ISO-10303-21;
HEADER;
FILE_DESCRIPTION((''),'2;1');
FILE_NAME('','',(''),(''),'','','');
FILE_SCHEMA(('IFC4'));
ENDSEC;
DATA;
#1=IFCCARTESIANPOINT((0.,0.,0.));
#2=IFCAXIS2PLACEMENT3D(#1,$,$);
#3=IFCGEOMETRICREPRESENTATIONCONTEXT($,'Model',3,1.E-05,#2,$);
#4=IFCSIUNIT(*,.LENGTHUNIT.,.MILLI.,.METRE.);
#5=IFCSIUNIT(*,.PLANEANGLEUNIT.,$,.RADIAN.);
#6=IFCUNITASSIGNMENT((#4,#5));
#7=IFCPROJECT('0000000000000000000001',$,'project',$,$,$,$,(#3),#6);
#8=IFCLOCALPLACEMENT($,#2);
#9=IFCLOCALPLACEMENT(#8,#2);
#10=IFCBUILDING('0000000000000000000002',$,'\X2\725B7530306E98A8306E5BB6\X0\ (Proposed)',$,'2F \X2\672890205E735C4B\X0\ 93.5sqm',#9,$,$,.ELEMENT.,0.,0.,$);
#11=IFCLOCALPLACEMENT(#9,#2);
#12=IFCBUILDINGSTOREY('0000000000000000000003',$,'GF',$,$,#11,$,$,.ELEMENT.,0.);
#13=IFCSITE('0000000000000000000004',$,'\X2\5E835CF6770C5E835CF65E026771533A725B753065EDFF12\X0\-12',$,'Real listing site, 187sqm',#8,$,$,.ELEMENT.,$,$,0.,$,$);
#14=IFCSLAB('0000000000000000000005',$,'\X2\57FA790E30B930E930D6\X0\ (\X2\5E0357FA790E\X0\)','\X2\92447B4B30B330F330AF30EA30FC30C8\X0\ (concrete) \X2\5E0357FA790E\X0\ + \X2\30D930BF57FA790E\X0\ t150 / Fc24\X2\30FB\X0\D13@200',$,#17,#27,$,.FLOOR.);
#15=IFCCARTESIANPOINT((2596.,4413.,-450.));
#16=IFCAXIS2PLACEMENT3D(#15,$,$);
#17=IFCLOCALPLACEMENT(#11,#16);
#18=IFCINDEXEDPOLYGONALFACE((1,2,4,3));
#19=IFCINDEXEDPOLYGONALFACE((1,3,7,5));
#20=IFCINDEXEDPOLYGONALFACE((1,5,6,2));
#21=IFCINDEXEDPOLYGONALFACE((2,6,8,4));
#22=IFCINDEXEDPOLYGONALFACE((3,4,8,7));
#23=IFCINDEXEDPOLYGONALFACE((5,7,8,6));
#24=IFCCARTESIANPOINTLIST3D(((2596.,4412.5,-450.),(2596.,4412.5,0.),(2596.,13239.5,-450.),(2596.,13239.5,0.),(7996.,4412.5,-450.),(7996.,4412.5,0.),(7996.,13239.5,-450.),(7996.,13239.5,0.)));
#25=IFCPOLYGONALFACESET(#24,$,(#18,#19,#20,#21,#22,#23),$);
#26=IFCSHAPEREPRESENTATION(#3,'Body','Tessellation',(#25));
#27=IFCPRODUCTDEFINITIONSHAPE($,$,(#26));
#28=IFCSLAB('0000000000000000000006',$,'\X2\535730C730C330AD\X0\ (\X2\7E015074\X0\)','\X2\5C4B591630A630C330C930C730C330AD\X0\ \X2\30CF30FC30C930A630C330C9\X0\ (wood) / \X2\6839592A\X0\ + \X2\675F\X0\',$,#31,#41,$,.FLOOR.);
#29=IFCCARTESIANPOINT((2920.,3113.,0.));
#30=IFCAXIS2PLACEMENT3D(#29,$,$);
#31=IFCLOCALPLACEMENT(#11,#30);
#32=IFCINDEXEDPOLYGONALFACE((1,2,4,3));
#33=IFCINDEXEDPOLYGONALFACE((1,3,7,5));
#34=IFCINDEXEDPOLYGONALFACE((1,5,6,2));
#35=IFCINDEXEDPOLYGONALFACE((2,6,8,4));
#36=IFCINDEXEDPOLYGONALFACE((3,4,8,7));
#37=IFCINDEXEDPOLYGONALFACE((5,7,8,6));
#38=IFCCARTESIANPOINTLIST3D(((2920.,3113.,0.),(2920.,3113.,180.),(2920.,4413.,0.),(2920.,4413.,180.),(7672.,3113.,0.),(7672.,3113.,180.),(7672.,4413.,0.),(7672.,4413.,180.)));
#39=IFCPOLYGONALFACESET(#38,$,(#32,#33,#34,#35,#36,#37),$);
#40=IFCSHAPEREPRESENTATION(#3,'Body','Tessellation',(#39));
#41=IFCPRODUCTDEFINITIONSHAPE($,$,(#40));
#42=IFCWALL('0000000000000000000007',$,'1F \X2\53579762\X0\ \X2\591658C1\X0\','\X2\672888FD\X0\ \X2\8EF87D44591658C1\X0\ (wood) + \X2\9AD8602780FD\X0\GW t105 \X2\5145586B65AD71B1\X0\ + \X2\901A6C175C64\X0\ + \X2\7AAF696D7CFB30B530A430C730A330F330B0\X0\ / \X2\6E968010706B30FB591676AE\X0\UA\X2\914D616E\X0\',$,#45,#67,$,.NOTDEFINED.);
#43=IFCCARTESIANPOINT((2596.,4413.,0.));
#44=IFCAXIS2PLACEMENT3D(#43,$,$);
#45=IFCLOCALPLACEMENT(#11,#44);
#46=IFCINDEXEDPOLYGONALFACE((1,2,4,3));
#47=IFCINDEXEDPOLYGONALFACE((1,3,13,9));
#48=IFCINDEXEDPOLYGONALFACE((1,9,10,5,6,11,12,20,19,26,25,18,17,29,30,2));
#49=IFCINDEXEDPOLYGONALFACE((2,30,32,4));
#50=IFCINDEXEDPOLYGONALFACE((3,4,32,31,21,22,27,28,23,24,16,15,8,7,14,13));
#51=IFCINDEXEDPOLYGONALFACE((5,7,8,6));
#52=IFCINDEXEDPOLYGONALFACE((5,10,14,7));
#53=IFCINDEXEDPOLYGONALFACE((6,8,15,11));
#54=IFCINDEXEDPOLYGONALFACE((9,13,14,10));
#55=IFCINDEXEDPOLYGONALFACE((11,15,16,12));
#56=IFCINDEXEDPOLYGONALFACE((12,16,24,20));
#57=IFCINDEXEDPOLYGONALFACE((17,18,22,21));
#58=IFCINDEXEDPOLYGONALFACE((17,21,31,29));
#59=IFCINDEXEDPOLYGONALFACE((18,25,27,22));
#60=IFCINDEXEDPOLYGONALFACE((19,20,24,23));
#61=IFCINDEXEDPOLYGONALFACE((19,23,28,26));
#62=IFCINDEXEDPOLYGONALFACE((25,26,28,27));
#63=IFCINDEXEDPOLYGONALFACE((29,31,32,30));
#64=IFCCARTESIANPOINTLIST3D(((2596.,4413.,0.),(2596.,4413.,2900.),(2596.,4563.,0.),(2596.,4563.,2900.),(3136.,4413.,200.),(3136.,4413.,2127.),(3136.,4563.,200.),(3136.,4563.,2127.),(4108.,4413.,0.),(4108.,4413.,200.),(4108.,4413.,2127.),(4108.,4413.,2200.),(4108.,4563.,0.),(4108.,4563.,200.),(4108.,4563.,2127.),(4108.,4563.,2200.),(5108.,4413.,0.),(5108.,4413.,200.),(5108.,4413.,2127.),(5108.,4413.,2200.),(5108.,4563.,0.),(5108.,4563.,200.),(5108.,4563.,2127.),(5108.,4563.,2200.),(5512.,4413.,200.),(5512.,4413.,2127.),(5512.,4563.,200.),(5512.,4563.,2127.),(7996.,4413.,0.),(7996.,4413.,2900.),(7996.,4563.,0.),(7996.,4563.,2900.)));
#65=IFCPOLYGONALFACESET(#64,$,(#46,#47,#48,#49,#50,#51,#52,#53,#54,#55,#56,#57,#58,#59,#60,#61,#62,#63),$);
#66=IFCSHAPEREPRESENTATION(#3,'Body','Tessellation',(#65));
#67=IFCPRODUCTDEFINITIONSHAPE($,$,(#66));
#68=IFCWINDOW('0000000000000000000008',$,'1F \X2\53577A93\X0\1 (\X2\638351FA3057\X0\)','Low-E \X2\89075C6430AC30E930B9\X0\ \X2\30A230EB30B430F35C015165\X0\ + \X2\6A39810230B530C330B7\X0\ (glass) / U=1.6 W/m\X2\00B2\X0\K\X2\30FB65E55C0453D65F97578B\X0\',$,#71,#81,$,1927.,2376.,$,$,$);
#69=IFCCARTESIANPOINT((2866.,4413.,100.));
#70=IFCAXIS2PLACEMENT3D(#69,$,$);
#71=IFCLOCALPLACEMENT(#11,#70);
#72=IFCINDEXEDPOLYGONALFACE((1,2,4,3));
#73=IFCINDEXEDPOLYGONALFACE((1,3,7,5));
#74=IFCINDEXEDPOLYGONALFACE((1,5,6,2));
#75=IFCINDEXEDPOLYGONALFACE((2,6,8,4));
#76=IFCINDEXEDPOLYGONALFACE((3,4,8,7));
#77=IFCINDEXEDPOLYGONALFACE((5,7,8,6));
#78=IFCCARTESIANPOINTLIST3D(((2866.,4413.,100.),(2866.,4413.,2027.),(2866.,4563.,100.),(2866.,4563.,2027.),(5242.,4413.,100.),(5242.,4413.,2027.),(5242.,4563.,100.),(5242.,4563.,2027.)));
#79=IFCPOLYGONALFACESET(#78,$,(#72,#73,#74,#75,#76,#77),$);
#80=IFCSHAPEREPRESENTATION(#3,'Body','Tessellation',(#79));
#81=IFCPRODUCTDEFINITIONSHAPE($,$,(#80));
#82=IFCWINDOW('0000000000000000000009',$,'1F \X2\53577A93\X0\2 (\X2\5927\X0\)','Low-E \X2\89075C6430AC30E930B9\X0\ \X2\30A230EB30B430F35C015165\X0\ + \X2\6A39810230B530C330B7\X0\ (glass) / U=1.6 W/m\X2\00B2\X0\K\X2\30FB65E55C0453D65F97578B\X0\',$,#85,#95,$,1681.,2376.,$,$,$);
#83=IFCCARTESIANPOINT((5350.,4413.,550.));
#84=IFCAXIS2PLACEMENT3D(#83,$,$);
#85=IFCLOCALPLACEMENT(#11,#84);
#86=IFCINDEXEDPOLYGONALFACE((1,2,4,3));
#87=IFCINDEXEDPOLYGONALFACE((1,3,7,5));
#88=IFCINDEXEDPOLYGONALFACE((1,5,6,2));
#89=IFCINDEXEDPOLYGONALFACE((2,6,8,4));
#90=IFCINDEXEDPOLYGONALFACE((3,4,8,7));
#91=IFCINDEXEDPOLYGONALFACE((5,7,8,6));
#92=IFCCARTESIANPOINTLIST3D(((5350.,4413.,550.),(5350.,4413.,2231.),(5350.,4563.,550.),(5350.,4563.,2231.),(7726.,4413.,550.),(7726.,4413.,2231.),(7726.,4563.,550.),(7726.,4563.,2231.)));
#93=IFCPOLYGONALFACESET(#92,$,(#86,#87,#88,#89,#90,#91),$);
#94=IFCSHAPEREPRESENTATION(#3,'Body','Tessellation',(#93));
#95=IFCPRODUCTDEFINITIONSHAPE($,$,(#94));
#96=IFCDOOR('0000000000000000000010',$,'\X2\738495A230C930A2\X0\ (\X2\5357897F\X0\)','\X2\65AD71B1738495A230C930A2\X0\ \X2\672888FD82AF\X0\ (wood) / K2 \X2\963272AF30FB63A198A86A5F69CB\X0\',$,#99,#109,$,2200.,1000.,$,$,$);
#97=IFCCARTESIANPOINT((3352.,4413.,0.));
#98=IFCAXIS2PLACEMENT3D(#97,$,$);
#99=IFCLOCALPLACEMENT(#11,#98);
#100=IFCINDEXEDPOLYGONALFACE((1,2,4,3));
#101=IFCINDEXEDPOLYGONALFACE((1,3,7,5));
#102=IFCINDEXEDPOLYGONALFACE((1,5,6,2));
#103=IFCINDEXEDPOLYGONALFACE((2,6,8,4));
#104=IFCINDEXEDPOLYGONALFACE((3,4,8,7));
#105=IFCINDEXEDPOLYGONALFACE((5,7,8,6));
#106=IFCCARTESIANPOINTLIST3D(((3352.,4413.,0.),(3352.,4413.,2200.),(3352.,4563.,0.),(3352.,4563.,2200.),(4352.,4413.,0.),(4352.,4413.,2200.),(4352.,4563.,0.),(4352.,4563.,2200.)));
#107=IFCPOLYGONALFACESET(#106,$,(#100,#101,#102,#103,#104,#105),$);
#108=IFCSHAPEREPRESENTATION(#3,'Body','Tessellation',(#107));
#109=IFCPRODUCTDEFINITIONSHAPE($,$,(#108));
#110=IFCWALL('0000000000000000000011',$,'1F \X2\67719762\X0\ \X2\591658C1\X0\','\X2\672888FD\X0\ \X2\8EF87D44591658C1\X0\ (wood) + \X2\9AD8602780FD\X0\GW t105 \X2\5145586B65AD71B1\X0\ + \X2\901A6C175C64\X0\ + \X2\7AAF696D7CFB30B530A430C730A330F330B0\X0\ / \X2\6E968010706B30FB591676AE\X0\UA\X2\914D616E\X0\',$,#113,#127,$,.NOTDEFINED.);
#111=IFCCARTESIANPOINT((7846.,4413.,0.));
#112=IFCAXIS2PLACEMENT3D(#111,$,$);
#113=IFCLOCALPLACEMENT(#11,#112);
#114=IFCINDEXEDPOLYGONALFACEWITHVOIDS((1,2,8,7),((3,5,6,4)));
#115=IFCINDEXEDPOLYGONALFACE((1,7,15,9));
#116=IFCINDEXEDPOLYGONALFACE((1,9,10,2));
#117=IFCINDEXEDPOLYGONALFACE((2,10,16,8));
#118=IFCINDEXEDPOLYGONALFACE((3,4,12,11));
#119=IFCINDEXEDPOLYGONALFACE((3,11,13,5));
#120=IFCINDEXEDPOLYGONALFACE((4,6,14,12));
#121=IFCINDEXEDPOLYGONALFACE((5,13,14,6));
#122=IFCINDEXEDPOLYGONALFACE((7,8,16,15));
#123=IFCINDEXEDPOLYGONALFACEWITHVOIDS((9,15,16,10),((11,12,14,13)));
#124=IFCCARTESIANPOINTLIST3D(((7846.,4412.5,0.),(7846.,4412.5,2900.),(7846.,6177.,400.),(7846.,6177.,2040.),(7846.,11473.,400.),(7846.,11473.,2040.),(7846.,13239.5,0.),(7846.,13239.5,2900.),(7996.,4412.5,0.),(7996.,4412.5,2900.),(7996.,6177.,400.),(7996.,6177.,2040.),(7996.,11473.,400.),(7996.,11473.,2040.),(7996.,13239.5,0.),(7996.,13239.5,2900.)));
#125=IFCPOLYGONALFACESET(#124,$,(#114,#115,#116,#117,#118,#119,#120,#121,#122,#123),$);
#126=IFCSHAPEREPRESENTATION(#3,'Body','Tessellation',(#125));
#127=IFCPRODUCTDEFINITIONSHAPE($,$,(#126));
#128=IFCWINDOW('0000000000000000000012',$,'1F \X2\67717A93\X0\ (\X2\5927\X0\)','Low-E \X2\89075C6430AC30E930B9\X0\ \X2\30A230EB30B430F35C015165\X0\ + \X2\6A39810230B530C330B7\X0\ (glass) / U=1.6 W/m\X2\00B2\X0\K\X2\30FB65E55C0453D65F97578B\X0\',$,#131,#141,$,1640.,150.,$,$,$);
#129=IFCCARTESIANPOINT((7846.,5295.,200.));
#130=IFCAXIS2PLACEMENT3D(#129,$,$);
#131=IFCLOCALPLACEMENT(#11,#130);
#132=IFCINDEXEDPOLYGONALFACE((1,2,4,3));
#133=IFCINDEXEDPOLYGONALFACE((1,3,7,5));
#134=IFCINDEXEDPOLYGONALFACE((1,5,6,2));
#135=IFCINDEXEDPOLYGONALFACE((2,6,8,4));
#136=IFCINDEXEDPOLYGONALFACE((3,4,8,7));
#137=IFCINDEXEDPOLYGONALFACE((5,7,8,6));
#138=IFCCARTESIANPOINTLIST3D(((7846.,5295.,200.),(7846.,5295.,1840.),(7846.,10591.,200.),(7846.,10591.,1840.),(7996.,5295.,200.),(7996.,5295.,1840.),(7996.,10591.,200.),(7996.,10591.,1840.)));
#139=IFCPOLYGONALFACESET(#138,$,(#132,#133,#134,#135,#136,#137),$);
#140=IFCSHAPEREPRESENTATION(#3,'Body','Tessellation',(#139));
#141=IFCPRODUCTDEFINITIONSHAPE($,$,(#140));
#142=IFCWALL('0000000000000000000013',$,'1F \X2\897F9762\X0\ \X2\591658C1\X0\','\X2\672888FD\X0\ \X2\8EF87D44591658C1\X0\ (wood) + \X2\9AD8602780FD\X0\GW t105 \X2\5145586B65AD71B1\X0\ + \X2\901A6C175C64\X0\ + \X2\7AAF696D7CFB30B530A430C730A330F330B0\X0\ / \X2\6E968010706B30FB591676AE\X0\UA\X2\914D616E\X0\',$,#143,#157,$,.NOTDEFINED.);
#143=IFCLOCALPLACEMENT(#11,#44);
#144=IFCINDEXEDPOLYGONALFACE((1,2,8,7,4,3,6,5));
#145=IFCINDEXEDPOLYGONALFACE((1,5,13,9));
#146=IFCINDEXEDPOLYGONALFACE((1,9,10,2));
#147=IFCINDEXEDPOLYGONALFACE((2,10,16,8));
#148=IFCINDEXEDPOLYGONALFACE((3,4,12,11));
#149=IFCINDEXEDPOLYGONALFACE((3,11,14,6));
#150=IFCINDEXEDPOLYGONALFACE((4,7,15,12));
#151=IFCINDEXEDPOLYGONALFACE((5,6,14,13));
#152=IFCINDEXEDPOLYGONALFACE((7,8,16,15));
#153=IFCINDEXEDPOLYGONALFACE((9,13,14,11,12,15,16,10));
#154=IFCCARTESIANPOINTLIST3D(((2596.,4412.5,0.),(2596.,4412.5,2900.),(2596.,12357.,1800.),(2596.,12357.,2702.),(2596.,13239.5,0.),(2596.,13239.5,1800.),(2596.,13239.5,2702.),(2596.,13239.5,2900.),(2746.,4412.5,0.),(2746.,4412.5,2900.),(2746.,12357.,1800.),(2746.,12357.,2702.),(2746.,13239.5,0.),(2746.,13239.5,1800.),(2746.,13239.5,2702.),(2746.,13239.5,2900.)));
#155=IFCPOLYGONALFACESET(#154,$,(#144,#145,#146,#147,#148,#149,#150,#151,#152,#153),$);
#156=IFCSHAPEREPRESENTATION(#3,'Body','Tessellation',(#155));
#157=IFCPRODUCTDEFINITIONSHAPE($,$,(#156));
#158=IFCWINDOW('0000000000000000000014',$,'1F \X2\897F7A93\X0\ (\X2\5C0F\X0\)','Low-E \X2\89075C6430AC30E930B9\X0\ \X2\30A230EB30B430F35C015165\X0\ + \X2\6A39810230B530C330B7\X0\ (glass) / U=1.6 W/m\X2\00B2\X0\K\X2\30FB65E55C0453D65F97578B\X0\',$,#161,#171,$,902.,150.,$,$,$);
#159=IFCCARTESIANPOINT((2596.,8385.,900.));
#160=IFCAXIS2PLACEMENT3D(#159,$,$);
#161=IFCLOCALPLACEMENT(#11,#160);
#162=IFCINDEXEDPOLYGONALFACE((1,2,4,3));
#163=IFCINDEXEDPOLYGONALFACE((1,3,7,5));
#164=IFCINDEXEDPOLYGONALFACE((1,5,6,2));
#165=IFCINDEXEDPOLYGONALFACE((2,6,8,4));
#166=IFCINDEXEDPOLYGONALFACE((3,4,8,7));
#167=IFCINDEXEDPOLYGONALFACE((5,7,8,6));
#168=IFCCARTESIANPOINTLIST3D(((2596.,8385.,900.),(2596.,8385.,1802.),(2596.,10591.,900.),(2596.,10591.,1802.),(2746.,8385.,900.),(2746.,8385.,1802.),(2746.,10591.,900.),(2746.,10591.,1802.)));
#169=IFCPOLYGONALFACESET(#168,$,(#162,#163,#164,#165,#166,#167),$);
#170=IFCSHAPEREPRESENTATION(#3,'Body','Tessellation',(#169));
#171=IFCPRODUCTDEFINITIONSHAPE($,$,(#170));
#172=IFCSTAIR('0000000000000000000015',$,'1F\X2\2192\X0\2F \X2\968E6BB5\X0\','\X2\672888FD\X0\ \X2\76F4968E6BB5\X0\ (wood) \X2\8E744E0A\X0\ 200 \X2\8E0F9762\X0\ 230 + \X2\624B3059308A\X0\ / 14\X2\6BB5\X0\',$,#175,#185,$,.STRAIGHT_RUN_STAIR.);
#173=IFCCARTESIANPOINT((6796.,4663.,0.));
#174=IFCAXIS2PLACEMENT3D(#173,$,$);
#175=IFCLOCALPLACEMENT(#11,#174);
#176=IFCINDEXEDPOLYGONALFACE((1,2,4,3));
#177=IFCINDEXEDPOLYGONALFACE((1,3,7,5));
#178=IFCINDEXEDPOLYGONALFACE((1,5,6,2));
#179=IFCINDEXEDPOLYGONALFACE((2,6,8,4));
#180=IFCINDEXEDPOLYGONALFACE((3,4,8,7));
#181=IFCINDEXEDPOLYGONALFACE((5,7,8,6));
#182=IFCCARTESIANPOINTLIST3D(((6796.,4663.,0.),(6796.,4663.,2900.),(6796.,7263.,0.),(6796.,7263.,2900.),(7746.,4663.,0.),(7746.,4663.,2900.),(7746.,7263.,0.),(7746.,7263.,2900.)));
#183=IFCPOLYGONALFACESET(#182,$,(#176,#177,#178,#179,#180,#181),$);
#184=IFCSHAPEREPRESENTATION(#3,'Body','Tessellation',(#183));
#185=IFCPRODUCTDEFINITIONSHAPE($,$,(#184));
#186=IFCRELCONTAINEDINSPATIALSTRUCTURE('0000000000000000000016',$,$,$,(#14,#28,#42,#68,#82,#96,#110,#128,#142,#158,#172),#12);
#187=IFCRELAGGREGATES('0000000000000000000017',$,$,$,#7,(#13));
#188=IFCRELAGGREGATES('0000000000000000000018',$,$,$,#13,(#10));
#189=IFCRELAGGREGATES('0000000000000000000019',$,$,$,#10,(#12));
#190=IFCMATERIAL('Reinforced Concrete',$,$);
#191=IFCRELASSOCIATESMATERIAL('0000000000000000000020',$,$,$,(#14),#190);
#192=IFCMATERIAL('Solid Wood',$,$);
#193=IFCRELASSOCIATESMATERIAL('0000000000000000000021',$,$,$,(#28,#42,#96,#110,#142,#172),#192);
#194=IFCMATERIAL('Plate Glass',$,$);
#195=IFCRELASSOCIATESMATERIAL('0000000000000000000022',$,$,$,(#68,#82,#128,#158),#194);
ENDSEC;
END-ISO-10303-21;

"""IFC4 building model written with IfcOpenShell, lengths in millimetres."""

from ifc_helpers import new_model, si_unit, frame, frame_2d, origin, place, context, project, spatial, rectangle, extrude, material, element, fill, save


model = new_model("IFC4")

# Units and contexts
model_context = context("Model", 3, precision=1e-05, world=origin())
ifc_project = project(units=[si_unit("LENGTHUNIT", "METRE", prefix="MILLI"), si_unit("PLANEANGLEUNIT", "RADIAN")], contexts=[model_context])

# Site, building, storey
site_placement = place(None, origin())
site = spatial("IfcSite", under=ifc_project, at=site_placement, Name="広島県広島市東区牛田旭２-12", ObjectType="Real listing site, 187sqm", CompositionType="ELEMENT", RefElevation=0.0)
building_placement = place(site_placement, origin())
building = spatial("IfcBuilding", under=site, at=building_placement, Name="牛田の風の家 (Proposed)", ObjectType="2F 木造平屋 93.5sqm", CompositionType="ELEMENT", ElevationOfRefHeight=0.0, ElevationOfTerrain=0.0)
storey_placement = place(building_placement, origin())
storey = spatial("IfcBuildingStorey", under=building, at=storey_placement, Name="GF", CompositionType="ELEMENT", Elevation=0.0)

# Slabs
ifc_material_1 = material(Name="Reinforced Concrete")
slab_1_placement = place(storey_placement, frame((2596.0, 4413.0, -450.0)))
element("IfcSlab", 1, at=slab_1_placement, inside=storey, material=ifc_material_1, Name="基礎スラブ (布基礎)", Description="鉄筋コンクリート (concrete) 布基礎 + ベタ基礎 t150 / Fc24・D13@200", PredefinedType="FLOOR", context=model_context, shape_type="SweptSolid", body=[
    extrude(rectangle(XDim=5400.0, YDim=8827.0, at=frame_2d((2700.0, 4413.0))), frame((2596.0, 4413.0, -450.0)), (0.0, 0.0, 1.0), 450.0),
])
ifc_material_2 = material(Name="Solid Wood")
slab_2_placement = place(storey_placement, frame((2920.0, 3113.0, 0.0)))
element("IfcSlab", 2, at=slab_2_placement, inside=storey, material=ifc_material_2, Name="南デッキ (縁側)", Description="屋外ウッドデッキ ハードウッド (wood) / 根太 + 束", PredefinedType="FLOOR", context=model_context, shape_type="SweptSolid", body=[
    extrude(rectangle(XDim=4752.0, YDim=1300.0, at=frame_2d((2376.0, 650.0))), frame((2920.0, 3113.0, 0.0)), (0.0, 0.0, 1.0), 180.0),
])

# Wall, openings, windows, door
wall_1_placement = place(storey_placement, frame((2596.0, 4413.0, 0.0)))
wall_1 = element("IfcWall", 3, at=wall_1_placement, inside=storey, material=ifc_material_2, Name="1F 南面 外壁", Description="木製 軸組外壁 (wood) + 高性能GW t105 充填断熱 + 通気層 + 窯業系サイディング / 準耐火・外皮UA配慮", PredefinedType="NOTDEFINED", context=model_context, shape_type="SweptSolid", body=[
    extrude(rectangle(XDim=5400.0, YDim=150.0, at=frame_2d((2700.0, 75.0))), frame((2596.0, 4413.0, 0.0)), (0.0, 0.0, 1.0), 2900.0),
])
opening_1_placement = place(storey_placement, frame((2866.0, 4413.0, 100.0)))
opening_1 = element("IfcOpeningElement", 4, at=opening_1_placement, cuts=wall_1, PredefinedType="NOTDEFINED", context=model_context, shape_type="SweptSolid", body=[
    extrude(rectangle(XDim=2376.0, YDim=150.0, at=frame_2d((1188.0, 75.0))), frame((2866.0, 4413.0, 100.0)), (0.0, 0.0, 1.0), 1927.0),
])
opening_2_placement = place(storey_placement, frame((5350.0, 4413.0, 550.0)))
opening_2 = element("IfcOpeningElement", 5, at=opening_2_placement, cuts=wall_1, PredefinedType="NOTDEFINED", context=model_context, shape_type="SweptSolid", body=[
    extrude(rectangle(XDim=2376.0, YDim=150.0, at=frame_2d((1188.0, 75.0))), frame((5350.0, 4413.0, 550.0)), (0.0, 0.0, 1.0), 1681.0),
])
opening_3_placement = place(storey_placement, frame((3352.0, 4413.0, 0.0)))
opening_3 = element("IfcOpeningElement", 6, at=opening_3_placement, cuts=wall_1, PredefinedType="NOTDEFINED", context=model_context, shape_type="SweptSolid", body=[
    extrude(rectangle(XDim=1000.0, YDim=150.0, at=frame_2d((500.0, 75.0))), frame((3352.0, 4413.0, 0.0)), (0.0, 0.0, 1.0), 2200.0),
])
ifc_material_3 = material(Name="Plate Glass")
window_1_placement = place(storey_placement, frame((2866.0, 4413.0, 100.0)))
window_1 = element("IfcWindow", 7, at=window_1_placement, inside=storey, material=ifc_material_3, Name="1F 南窓1 (掃出し)", Description="Low-E 複層ガラス アルゴン封入 + 樹脂サッシ (glass) / U=1.6 W/m²K・日射取得型", OverallHeight=1927.0, OverallWidth=2376.0, context=model_context, shape_type="SweptSolid", body=[
    extrude(rectangle(XDim=2376.0, YDim=150.0, at=frame_2d((1188.0, 75.0))), frame((2866.0, 4413.0, 100.0)), (0.0, 0.0, 1.0), 1927.0),
])
fill(opening_1, window_1)
window_2_placement = place(storey_placement, frame((5350.0, 4413.0, 550.0)))
window_2 = element("IfcWindow", 8, at=window_2_placement, inside=storey, material=ifc_material_3, Name="1F 南窓2 (大)", Description="Low-E 複層ガラス アルゴン封入 + 樹脂サッシ (glass) / U=1.6 W/m²K・日射取得型", OverallHeight=1681.0, OverallWidth=2376.0, context=model_context, shape_type="SweptSolid", body=[
    extrude(rectangle(XDim=2376.0, YDim=150.0, at=frame_2d((1188.0, 75.0))), frame((5350.0, 4413.0, 550.0)), (0.0, 0.0, 1.0), 1681.0),
])
fill(opening_2, window_2)
door_placement = place(storey_placement, frame((3352.0, 4413.0, 0.0)))
door = element("IfcDoor", 9, at=door_placement, inside=storey, material=ifc_material_2, Name="玄関ドア (南西)", Description="断熱玄関ドア 木製芯 (wood) / K2 防犯・採風機構", OverallHeight=2200.0, OverallWidth=1000.0, context=model_context, shape_type="SweptSolid", body=[
    extrude(rectangle(XDim=1000.0, YDim=150.0, at=frame_2d((500.0, 75.0))), frame((3352.0, 4413.0, 0.0)), (0.0, 0.0, 1.0), 2200.0),
])
fill(opening_3, door)

# Walls, openings, windows
wall_2_placement = place(storey_placement, frame((7846.0, 4413.0, 0.0)))
wall_2 = element("IfcWall", 10, at=wall_2_placement, inside=storey, material=ifc_material_2, Name="1F 東面 外壁", Description="木製 軸組外壁 (wood) + 高性能GW t105 充填断熱 + 通気層 + 窯業系サイディング / 準耐火・外皮UA配慮", PredefinedType="NOTDEFINED", context=model_context, shape_type="SweptSolid", body=[
    extrude(rectangle(XDim=150.0, YDim=8827.0, at=frame_2d((75.0, 4413.0))), frame((7846.0, 4413.0, 0.0)), (0.0, 0.0, 1.0), 2900.0),
])
opening_4_placement = place(storey_placement, frame((7846.0, 5295.0, 200.0)))
opening_4 = element("IfcOpeningElement", 11, at=opening_4_placement, cuts=wall_2, PredefinedType="NOTDEFINED", context=model_context, shape_type="SweptSolid", body=[
    extrude(rectangle(XDim=150.0, YDim=5296.0, at=frame_2d((75.0, 2648.0))), frame((7846.0, 5295.0, 200.0)), (0.0, 0.0, 1.0), 1640.0),
])
window_3_placement = place(storey_placement, frame((7846.0, 5295.0, 200.0)))
window_3 = element("IfcWindow", 12, at=window_3_placement, inside=storey, material=ifc_material_3, Name="1F 東窓 (大)", Description="Low-E 複層ガラス アルゴン封入 + 樹脂サッシ (glass) / U=1.6 W/m²K・日射取得型", OverallHeight=1640.0, OverallWidth=150.0, context=model_context, shape_type="SweptSolid", body=[
    extrude(rectangle(XDim=150.0, YDim=5296.0, at=frame_2d((75.0, 2648.0))), frame((7846.0, 5295.0, 200.0)), (0.0, 0.0, 1.0), 1640.0),
])
fill(opening_4, window_3)
wall_3_placement = place(storey_placement, frame((2596.0, 4413.0, 0.0)))
wall_3 = element("IfcWall", 13, at=wall_3_placement, inside=storey, material=ifc_material_2, Name="1F 西面 外壁", Description="木製 軸組外壁 (wood) + 高性能GW t105 充填断熱 + 通気層 + 窯業系サイディング / 準耐火・外皮UA配慮", PredefinedType="NOTDEFINED", context=model_context, shape_type="SweptSolid", body=[
    extrude(rectangle(XDim=150.0, YDim=8827.0, at=frame_2d((75.0, 4413.0))), frame((2596.0, 4413.0, 0.0)), (0.0, 0.0, 1.0), 2900.0),
])
opening_5_placement = place(storey_placement, frame((2596.0, 8385.0, 900.0)))
opening_5 = element("IfcOpeningElement", 14, at=opening_5_placement, cuts=wall_3, PredefinedType="NOTDEFINED", context=model_context, shape_type="SweptSolid", body=[
    extrude(rectangle(XDim=150.0, YDim=2206.0, at=frame_2d((75.0, 1103.0))), frame((2596.0, 8385.0, 900.0)), (0.0, 0.0, 1.0), 902.0),
])
window_4_placement = place(storey_placement, frame((2596.0, 8385.0, 900.0)))
window_4 = element("IfcWindow", 15, at=window_4_placement, inside=storey, material=ifc_material_3, Name="1F 西窓 (小)", Description="Low-E 複層ガラス アルゴン封入 + 樹脂サッシ (glass) / U=1.6 W/m²K・日射取得型", OverallHeight=902.0, OverallWidth=150.0, context=model_context, shape_type="SweptSolid", body=[
    extrude(rectangle(XDim=150.0, YDim=2206.0, at=frame_2d((75.0, 1103.0))), frame((2596.0, 8385.0, 900.0)), (0.0, 0.0, 1.0), 902.0),
])
fill(opening_5, window_4)

# Stair
stair_placement = place(storey_placement, frame((6796.0, 4663.0, 0.0)))
element("IfcStair", 16, at=stair_placement, inside=storey, material=ifc_material_2, Name="1F→2F 階段", Description="木製 直階段 (wood) 蹴上 200 踏面 230 + 手すり / 14段", PredefinedType="STRAIGHT_RUN_STAIR", context=model_context, shape_type="SweptSolid", body=[
    extrude(rectangle(XDim=950.0, YDim=2600.0, at=frame_2d((475.0, 1300.0))), frame((6796.0, 4663.0, 0.0)), (0.0, 0.0, 1.0), 2900.0),
])

save(model, "model.ifc")
